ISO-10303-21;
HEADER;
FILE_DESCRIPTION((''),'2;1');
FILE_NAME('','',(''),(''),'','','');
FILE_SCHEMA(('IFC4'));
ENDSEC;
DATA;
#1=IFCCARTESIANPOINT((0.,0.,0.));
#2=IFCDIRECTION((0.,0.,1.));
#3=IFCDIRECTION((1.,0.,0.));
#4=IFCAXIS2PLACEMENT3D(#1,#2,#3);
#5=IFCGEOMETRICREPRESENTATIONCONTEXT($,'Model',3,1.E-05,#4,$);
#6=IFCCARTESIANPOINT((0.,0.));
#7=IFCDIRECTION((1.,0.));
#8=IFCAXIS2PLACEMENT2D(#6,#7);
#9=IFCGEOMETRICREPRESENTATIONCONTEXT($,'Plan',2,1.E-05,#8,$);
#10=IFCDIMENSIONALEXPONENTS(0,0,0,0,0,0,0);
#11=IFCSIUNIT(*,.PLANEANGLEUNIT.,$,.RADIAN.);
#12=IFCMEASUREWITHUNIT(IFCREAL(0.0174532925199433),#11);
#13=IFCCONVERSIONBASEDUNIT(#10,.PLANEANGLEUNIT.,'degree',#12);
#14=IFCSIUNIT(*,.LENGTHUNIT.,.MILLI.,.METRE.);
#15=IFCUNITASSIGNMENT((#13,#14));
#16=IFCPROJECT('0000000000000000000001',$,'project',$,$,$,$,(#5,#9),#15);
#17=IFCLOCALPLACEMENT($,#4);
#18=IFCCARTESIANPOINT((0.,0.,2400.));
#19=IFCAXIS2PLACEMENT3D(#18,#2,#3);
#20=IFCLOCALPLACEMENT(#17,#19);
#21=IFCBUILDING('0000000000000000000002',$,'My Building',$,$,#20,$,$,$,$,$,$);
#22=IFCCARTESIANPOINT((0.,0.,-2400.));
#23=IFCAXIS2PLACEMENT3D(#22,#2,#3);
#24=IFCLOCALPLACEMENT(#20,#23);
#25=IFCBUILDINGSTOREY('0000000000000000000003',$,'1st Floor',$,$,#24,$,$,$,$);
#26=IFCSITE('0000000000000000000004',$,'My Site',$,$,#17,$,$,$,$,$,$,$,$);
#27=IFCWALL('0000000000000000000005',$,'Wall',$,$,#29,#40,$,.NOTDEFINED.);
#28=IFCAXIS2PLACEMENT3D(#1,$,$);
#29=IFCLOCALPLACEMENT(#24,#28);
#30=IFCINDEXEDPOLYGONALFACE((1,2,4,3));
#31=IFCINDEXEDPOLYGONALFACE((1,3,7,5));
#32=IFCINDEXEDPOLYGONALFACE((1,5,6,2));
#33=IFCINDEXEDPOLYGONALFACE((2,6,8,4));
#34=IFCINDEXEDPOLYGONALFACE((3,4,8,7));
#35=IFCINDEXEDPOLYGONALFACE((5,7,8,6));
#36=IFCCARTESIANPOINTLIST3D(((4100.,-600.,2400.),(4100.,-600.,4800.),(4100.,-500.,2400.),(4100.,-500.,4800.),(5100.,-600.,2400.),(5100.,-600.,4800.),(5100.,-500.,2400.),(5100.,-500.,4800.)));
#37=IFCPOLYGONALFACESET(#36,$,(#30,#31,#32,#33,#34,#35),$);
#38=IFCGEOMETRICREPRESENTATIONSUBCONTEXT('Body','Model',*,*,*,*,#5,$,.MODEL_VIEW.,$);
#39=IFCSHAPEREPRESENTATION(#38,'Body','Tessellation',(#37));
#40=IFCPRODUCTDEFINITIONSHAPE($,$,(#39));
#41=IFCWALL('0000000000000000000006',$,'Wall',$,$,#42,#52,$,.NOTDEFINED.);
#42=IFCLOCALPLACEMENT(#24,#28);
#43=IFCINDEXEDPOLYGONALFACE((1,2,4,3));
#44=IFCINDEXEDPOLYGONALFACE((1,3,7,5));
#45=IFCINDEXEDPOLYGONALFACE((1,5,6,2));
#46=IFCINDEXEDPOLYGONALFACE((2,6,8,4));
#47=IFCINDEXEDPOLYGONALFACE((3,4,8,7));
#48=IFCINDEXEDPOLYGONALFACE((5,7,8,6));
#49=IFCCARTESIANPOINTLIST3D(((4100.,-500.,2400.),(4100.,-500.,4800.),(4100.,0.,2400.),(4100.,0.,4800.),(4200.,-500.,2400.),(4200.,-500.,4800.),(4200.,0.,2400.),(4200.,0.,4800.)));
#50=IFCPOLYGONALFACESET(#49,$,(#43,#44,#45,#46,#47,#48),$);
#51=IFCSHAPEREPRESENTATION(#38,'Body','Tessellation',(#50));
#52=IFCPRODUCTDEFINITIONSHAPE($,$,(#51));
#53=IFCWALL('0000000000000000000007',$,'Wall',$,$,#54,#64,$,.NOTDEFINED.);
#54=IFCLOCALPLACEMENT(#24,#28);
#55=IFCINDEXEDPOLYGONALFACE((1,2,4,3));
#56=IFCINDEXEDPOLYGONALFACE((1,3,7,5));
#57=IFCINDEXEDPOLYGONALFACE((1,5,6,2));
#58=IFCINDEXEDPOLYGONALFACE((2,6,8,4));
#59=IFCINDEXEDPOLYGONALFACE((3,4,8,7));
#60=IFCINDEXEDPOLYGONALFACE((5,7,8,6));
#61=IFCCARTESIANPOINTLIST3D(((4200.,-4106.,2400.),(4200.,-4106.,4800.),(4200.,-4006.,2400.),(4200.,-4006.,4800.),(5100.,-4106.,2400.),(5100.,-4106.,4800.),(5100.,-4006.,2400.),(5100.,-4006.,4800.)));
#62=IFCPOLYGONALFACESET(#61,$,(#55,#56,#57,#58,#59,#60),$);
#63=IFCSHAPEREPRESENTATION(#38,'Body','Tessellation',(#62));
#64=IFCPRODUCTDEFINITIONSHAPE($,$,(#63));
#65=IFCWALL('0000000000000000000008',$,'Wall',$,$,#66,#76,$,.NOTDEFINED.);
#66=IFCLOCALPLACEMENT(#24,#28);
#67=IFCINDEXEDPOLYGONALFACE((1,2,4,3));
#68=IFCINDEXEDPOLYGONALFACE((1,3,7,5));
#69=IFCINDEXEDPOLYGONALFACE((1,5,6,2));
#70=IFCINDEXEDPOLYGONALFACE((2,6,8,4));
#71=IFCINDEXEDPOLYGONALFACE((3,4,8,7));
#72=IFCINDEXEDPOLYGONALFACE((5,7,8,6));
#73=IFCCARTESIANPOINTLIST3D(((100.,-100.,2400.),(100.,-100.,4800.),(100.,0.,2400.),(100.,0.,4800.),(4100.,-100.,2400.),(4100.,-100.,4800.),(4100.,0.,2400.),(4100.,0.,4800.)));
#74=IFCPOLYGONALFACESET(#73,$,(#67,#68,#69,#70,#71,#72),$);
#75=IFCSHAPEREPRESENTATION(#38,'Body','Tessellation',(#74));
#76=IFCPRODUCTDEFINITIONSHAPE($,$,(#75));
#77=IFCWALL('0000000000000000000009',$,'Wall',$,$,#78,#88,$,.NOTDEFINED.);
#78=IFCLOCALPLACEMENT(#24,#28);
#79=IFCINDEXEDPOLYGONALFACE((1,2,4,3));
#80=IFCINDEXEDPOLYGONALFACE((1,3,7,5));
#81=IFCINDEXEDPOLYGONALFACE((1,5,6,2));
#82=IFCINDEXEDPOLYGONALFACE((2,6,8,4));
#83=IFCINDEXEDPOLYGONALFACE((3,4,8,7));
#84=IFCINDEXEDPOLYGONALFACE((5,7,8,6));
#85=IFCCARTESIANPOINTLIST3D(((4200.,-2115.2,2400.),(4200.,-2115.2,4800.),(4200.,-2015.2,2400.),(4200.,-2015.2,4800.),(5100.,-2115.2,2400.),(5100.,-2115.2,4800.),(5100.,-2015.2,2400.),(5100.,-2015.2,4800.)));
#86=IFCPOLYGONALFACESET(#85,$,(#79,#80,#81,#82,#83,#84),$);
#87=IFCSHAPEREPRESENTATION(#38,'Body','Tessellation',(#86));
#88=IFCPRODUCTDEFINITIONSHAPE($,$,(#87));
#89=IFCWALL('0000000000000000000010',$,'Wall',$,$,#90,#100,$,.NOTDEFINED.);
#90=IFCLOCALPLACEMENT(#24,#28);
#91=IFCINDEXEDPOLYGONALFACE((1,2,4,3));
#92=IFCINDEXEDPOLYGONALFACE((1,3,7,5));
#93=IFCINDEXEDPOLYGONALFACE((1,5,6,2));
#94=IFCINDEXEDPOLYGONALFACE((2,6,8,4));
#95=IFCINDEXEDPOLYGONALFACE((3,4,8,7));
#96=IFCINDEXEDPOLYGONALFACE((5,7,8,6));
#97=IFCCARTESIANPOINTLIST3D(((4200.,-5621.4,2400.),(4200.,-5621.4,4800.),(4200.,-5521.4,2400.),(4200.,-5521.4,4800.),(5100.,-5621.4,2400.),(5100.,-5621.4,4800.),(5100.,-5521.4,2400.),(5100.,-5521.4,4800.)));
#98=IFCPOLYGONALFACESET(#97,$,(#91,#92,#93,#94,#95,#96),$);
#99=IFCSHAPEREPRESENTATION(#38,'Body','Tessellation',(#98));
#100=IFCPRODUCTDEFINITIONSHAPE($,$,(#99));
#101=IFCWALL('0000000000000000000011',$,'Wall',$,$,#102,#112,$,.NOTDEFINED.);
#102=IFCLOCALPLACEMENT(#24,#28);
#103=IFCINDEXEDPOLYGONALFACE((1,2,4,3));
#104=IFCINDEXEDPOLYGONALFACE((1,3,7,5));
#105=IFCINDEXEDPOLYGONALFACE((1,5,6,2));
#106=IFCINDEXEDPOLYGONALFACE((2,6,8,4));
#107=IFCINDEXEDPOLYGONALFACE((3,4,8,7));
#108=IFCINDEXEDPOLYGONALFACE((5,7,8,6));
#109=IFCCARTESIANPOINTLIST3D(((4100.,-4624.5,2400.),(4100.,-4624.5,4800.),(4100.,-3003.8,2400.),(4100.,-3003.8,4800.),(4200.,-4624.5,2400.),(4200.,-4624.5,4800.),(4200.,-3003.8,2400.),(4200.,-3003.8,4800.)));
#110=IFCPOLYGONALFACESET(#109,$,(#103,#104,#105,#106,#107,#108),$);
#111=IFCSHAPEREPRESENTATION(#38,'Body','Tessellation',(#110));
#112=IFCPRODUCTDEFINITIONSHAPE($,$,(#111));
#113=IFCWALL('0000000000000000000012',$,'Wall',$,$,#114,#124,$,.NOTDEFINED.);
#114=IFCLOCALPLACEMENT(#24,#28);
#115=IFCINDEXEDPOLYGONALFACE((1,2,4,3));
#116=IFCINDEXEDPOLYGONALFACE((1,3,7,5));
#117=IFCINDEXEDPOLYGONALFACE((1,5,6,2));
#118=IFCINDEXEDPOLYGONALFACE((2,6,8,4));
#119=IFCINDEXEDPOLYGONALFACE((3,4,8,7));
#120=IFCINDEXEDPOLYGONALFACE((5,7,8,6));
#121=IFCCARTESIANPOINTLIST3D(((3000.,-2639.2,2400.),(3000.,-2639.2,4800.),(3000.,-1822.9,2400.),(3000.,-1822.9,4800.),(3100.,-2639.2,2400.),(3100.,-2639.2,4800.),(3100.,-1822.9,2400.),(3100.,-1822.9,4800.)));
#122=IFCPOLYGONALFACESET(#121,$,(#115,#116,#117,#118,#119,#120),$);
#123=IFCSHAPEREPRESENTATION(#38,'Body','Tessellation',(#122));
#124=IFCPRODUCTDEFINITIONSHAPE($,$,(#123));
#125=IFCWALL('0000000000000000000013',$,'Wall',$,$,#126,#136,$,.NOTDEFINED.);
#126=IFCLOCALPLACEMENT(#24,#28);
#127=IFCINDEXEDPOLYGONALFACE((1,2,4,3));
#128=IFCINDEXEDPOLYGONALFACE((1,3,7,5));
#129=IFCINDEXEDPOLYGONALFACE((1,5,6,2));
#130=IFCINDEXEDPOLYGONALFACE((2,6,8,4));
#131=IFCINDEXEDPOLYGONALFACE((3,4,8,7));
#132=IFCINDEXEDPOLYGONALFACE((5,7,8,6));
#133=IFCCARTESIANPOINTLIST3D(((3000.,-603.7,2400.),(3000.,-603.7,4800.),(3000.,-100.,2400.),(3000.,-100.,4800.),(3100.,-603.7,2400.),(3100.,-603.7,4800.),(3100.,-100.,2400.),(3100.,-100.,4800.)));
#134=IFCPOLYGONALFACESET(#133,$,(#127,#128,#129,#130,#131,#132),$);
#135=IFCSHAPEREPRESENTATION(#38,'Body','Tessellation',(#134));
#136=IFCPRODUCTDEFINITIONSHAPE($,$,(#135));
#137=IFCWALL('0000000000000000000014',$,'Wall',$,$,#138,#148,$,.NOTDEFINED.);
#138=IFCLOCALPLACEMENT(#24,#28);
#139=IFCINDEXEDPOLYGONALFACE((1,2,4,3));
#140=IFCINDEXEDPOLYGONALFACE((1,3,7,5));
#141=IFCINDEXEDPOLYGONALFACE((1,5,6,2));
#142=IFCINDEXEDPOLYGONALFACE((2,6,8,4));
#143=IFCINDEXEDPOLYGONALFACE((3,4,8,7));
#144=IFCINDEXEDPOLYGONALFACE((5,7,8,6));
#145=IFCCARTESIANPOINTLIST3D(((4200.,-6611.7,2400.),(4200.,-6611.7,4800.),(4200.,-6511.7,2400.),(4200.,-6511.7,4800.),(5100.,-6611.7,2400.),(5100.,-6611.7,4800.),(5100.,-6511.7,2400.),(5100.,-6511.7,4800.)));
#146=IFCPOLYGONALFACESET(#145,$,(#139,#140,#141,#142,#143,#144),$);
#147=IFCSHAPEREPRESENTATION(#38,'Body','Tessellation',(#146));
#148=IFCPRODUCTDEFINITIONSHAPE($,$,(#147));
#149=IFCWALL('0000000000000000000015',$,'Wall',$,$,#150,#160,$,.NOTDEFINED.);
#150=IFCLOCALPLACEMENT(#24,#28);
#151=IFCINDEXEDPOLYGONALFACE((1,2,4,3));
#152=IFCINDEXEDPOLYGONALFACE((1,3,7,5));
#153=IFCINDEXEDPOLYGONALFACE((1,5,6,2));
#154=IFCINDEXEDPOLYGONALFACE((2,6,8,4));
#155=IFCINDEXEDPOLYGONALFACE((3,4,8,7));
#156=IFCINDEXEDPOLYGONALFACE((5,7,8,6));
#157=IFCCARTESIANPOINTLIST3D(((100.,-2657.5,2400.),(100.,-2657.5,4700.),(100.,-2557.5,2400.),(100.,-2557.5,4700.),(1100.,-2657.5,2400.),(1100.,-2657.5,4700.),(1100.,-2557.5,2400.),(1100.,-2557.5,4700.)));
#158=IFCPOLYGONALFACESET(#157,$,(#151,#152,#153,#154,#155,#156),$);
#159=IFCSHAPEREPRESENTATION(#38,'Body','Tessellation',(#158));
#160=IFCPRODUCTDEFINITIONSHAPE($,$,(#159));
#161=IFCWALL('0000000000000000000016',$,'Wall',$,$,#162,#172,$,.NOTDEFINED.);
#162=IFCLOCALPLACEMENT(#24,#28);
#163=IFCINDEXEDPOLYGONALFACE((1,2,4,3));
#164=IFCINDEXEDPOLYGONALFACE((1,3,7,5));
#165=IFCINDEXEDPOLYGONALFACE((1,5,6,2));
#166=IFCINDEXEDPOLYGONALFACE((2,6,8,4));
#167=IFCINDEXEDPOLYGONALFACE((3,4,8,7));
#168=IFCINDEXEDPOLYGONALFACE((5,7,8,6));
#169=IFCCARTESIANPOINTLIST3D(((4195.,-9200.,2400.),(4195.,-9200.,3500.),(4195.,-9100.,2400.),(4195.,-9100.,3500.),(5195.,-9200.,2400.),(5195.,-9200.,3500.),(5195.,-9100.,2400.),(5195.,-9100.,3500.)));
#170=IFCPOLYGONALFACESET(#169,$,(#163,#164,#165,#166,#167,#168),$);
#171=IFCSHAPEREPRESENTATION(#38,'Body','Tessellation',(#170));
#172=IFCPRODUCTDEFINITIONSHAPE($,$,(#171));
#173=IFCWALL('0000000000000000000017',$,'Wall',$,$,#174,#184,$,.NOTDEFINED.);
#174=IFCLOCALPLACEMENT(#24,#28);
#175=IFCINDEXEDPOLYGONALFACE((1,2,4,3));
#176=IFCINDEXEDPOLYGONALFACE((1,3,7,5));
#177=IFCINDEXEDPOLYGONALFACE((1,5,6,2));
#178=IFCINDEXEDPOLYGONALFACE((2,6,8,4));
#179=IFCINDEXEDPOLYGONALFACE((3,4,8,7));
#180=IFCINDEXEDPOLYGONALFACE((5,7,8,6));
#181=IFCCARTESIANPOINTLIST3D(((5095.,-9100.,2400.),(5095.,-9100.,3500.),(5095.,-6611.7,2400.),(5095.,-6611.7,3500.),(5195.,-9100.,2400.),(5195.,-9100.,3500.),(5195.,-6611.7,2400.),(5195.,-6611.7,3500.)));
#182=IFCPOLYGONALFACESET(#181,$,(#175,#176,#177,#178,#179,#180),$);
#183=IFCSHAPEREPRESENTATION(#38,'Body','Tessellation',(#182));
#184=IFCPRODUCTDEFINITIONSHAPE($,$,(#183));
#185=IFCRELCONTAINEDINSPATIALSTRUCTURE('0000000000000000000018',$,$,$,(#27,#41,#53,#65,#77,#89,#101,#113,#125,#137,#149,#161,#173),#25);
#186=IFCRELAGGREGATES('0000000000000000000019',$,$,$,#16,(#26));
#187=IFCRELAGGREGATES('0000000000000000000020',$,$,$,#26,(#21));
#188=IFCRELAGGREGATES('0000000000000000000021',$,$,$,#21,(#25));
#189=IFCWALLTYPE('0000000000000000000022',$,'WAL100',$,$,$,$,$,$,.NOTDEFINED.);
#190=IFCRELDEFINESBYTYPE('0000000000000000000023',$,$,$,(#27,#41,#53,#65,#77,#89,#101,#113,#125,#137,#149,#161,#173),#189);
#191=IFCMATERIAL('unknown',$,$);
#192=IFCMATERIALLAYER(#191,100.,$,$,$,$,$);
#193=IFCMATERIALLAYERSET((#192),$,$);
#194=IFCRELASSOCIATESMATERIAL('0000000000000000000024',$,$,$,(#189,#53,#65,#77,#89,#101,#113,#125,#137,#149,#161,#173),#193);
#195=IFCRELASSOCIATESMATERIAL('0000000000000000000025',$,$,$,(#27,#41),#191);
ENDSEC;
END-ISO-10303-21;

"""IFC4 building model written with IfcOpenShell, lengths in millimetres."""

from ifc_helpers import new_model, entity, si_unit, converted_unit, frame, origin_with_axes, origin_2d_with_axis, place, context, subcontext, project, spatial, indexed_curve, outline, extrude, material, layer, layer_set, layer_usage, type_object, element, save


model = new_model("IFC4")

# Units and contexts
model_context = context("Model", 3, precision=1e-05, world=origin_with_axes())
plan_context = context("Plan", 2, precision=1e-05, world=origin_2d_with_axis())
body_context = subcontext(model_context, "Body", "Model", "MODEL_VIEW")
ifc_project = project(units=[converted_unit("PLANEANGLEUNIT", "degree", entity("IfcReal", 0.0174532925199433), si_unit("PLANEANGLEUNIT", "RADIAN"), dimensions=[0, 0, 0, 0, 0, 0, 0]), si_unit("LENGTHUNIT", "METRE", prefix="MILLI")], contexts=[model_context, plan_context])

# Site, building, storey
site_placement = place(None, origin_with_axes())
site = spatial("IfcSite", under=ifc_project, at=site_placement, Name="My Site")
building_placement = place(site_placement, frame((0.0, 0.0, 2400.0), z_axis=(0.0, 0.0, 1.0), x_axis=(1.0, 0.0, 0.0)))
building = spatial("IfcBuilding", under=site, at=building_placement, Name="My Building")
storey_placement = place(building_placement, frame((0.0, 0.0, -2400.0), z_axis=(0.0, 0.0, 1.0), x_axis=(1.0, 0.0, 0.0)))
storey = spatial("IfcBuildingStorey", under=building, at=storey_placement, Name="1st Floor")

# Walls
ifc_material = material(Name="unknown")
ifc_layer = layer(ifc_material, 100.0)
ifc_layer_set = layer_set([ifc_layer])
wall_type = type_object("IfcWallType", Name="WAL100", PredefinedType="NOTDEFINED", material=ifc_layer_set)
wall_1_placement = place(storey_placement, frame((5100.0, -500.0, 2400.0), z_axis=(0.0, 0.0, 1.0), x_axis=(-1.0, 0.000002, 0.0)))
element("IfcWall", 1, at=wall_1_placement, inside=storey, type_object=wall_type, material=ifc_material, Name="Wall", PredefinedType="NOTDEFINED", context=body_context, shape_type="SweptSolid", body=[
    extrude(outline(indexed_curve([(0.0, 0.0), (0.0, 100.0), (1000.0, 100.0), (1000.0, 0.0), (0.0, 0.0)], self_intersect=False)), origin_with_axes(), (0.0, 0.0, 1.0), 2400.0),
])
wall_2_placement = place(storey_placement, frame((4100.0, 0.0, 2400.0), z_axis=(0.0, 0.0, 1.0), x_axis=(-0.000003, -1.0, 0.0)))
element("IfcWall", 2, at=wall_2_placement, inside=storey, type_object=wall_type, material=ifc_material, Name="Wall", PredefinedType="NOTDEFINED", context=body_context, shape_type="SweptSolid", body=[
    extrude(outline(indexed_curve([(0.0, 0.0), (0.0, 100.0), (500.0, 100.0), (500.0, 0.0), (0.0, 0.0)], self_intersect=False)), origin_with_axes(), (0.0, 0.0, 1.0), 2400.0),
])
ifc_layer_usage_1 = layer_usage(ifc_layer_set, "AXIS2", "POSITIVE", 0.0)
wall_3_placement = place(storey_placement, frame((4200.0, -4106.0, 2400.0), z_axis=(0.0, 0.0, 1.0), x_axis=(1.0, -0.000002, 0.0)))
element("IfcWall", 3, at=wall_3_placement, inside=storey, type_object=wall_type, material=ifc_layer_usage_1, Name="Wall", PredefinedType="NOTDEFINED", context=body_context, shape_type="SweptSolid", body=[
    extrude(outline(indexed_curve([(0.0, 0.0), (0.0, 100.0), (900.0, 100.0), (900.0, 0.0), (0.0, 0.0)], self_intersect=False)), origin_with_axes(), (0.0, 0.0, 1.0), 2400.0),
])
ifc_layer_usage_2 = layer_usage(ifc_layer_set, "AXIS2", "POSITIVE", 0.0)
wall_4_placement = place(storey_placement, frame((4100.0, 0.0, 2400.0), z_axis=(0.0, 0.0, 1.0), x_axis=(-1.0, 0.000003, 0.0)))
element("IfcWall", 4, at=wall_4_placement, inside=storey, type_object=wall_type, material=ifc_layer_usage_2, Name="Wall", PredefinedType="NOTDEFINED", context=body_context, shape_type="SweptSolid", body=[
    extrude(outline(indexed_curve([(0.0, 0.0), (0.0, 100.0), (4000.0, 100.0), (4000.0, 0.0), (0.0, 0.0)], self_intersect=False)), origin_with_axes(), (0.0, 0.0, 1.0), 2400.0),
])
ifc_layer_usage_3 = layer_usage(ifc_layer_set, "AXIS2", "POSITIVE", 0.0)
wall_5_placement = place(storey_placement, frame((4200.0, -2115.2, 2400.0), z_axis=(0.0, 0.0, 1.0), x_axis=(1.0, -0.000002, 0.0)))
element("IfcWall", 5, at=wall_5_placement, inside=storey, type_object=wall_type, material=ifc_layer_usage_3, Name="Wall", PredefinedType="NOTDEFINED", context=body_context, shape_type="SweptSolid", body=[
    extrude(outline(indexed_curve([(0.0, 0.0), (0.0, 100.0), (900.0, 100.0), (900.0, 0.0), (0.0, 0.0)], self_intersect=False)), origin_with_axes(), (0.0, 0.0, 1.0), 2400.0),
])
ifc_layer_usage_4 = layer_usage(ifc_layer_set, "AXIS2", "POSITIVE", 0.0)
wall_6_placement = place(storey_placement, frame((4200.0, -5621.4, 2400.0), z_axis=(0.0, 0.0, 1.0), x_axis=(1.0, -0.000002, 0.0)))
element("IfcWall", 6, at=wall_6_placement, inside=storey, type_object=wall_type, material=ifc_layer_usage_4, Name="Wall", PredefinedType="NOTDEFINED", context=body_context, shape_type="SweptSolid", body=[
    extrude(outline(indexed_curve([(0.0, 0.0), (0.0, 100.0), (900.0, 100.0), (900.0, 0.0), (0.0, 0.0)], self_intersect=False)), origin_with_axes(), (0.0, 0.0, 1.0), 2400.0),
])
ifc_layer_usage_5 = layer_usage(ifc_layer_set, "AXIS2", "POSITIVE", 0.0)
wall_7_placement = place(storey_placement, frame((4100.0, -3003.8, 2400.0), z_axis=(0.0, 0.0, 1.0), x_axis=(-0.000002, -1.0, 0.0)))
element("IfcWall", 7, at=wall_7_placement, inside=storey, type_object=wall_type, material=ifc_layer_usage_5, Name="Wall", PredefinedType="NOTDEFINED", context=body_context, shape_type="SweptSolid", body=[
    extrude(outline(indexed_curve([(0.0, 0.0), (0.0, 100.0), (1620.7, 100.0), (1620.7, 0.0), (0.0, 0.0)], self_intersect=False)), origin_with_axes(), (0.0, 0.0, 1.0), 2400.0),
])
ifc_layer_usage_6 = layer_usage(ifc_layer_set, "AXIS2", "POSITIVE", 0.0)
wall_8_placement = place(storey_placement, frame((3100.0, -2639.2, 2400.0), z_axis=(0.0, 0.0, 1.0), x_axis=(0.000003, 1.0, 0.0)))
element("IfcWall", 8, at=wall_8_placement, inside=storey, type_object=wall_type, material=ifc_layer_usage_6, Name="Wall", PredefinedType="NOTDEFINED", context=body_context, shape_type="SweptSolid", body=[
    extrude(outline(indexed_curve([(0.0, 0.0), (0.0, 100.0), (816.2, 100.0), (816.2, 0.0), (0.0, 0.0)], self_intersect=False)), origin_with_axes(), (0.0, 0.0, 1.0), 2400.0),
])
ifc_layer_usage_7 = layer_usage(ifc_layer_set, "AXIS2", "POSITIVE", 0.0)
wall_9_placement = place(storey_placement, frame((3100.0, -603.7, 2400.0), z_axis=(0.0, 0.0, 1.0), x_axis=(0.000003, 1.0, 0.0)))
element("IfcWall", 9, at=wall_9_placement, inside=storey, type_object=wall_type, material=ifc_layer_usage_7, Name="Wall", PredefinedType="NOTDEFINED", context=body_context, shape_type="SweptSolid", body=[
    extrude(outline(indexed_curve([(0.0, 0.0), (0.0, 100.0), (503.7, 100.0), (503.7, 0.0), (0.0, 0.0)], self_intersect=False)), origin_with_axes(), (0.0, 0.0, 1.0), 2400.0),
])
ifc_layer_usage_8 = layer_usage(ifc_layer_set, "AXIS2", "POSITIVE", 0.0)
wall_10_placement = place(storey_placement, frame((4200.0, -6611.7, 2400.0), z_axis=(0.0, 0.0, 1.0), x_axis=(1.0, 0.0, 0.0)))
element("IfcWall", 10, at=wall_10_placement, inside=storey, type_object=wall_type, material=ifc_layer_usage_8, Name="Wall", PredefinedType="NOTDEFINED", context=body_context, shape_type="SweptSolid", body=[
    extrude(outline(indexed_curve([(0.0, 0.0), (0.0, 100.0), (900.0, 100.0), (900.0, 0.0), (0.0, 0.0)], self_intersect=False)), origin_with_axes(), (0.0, 0.0, 1.0), 2400.0),
])
ifc_layer_usage_9 = layer_usage(ifc_layer_set, "AXIS2", "POSITIVE", 0.0)
wall_11_placement = place(storey_placement, frame((100.0, -2657.5, 2400.0), z_axis=(0.0, 0.0, 1.0), x_axis=(1.0, 0.0, 0.0)))
element("IfcWall", 11, at=wall_11_placement, inside=storey, type_object=wall_type, material=ifc_layer_usage_9, Name="Wall", PredefinedType="NOTDEFINED", context=body_context, shape_type="SweptSolid", body=[
    extrude(outline(indexed_curve([(0.0, 0.0), (0.0, 100.0), (1000.0, 100.0), (1000.0, 0.0), (0.0, 0.0)], self_intersect=False)), origin_with_axes(), (0.0, 0.0, 1.0), 2300.0),
])
ifc_layer_usage_10 = layer_usage(ifc_layer_set, "AXIS2", "POSITIVE", 0.0)
wall_12_placement = place(storey_placement, frame((4195.0, -9200.0, 2400.0), z_axis=(0.0, 0.0, 1.0), x_axis=(1.0, 0.0, 0.0)))
element("IfcWall", 12, at=wall_12_placement, inside=storey, type_object=wall_type, material=ifc_layer_usage_10, Name="Wall", PredefinedType="NOTDEFINED", context=body_context, shape_type="SweptSolid", body=[
    extrude(outline(indexed_curve([(0.0, 0.0), (0.0, 100.0), (1000.0, 100.0), (1000.0, 0.0), (0.0, 0.0)], self_intersect=False)), origin_with_axes(), (0.0, 0.0, 1.0), 1100.0),
])
ifc_layer_usage_11 = layer_usage(ifc_layer_set, "AXIS2", "POSITIVE", 0.0)
wall_13_placement = place(storey_placement, frame((5195.0, -9100.0, 2400.0), z_axis=(0.0, 0.0, 1.0), x_axis=(0.0, 1.0, 0.0)))
element("IfcWall", 13, at=wall_13_placement, inside=storey, type_object=wall_type, material=ifc_layer_usage_11, Name="Wall", PredefinedType="NOTDEFINED", context=body_context, shape_type="SweptSolid", body=[
    extrude(outline(indexed_curve([(0.0, 0.0), (0.0, 100.0), (2488.3, 100.0), (2488.3, 0.0), (0.0, 0.0)], self_intersect=False)), origin_with_axes(), (0.0, 0.0, 1.0), 1100.0),
])

save(model, "model.ifc")
